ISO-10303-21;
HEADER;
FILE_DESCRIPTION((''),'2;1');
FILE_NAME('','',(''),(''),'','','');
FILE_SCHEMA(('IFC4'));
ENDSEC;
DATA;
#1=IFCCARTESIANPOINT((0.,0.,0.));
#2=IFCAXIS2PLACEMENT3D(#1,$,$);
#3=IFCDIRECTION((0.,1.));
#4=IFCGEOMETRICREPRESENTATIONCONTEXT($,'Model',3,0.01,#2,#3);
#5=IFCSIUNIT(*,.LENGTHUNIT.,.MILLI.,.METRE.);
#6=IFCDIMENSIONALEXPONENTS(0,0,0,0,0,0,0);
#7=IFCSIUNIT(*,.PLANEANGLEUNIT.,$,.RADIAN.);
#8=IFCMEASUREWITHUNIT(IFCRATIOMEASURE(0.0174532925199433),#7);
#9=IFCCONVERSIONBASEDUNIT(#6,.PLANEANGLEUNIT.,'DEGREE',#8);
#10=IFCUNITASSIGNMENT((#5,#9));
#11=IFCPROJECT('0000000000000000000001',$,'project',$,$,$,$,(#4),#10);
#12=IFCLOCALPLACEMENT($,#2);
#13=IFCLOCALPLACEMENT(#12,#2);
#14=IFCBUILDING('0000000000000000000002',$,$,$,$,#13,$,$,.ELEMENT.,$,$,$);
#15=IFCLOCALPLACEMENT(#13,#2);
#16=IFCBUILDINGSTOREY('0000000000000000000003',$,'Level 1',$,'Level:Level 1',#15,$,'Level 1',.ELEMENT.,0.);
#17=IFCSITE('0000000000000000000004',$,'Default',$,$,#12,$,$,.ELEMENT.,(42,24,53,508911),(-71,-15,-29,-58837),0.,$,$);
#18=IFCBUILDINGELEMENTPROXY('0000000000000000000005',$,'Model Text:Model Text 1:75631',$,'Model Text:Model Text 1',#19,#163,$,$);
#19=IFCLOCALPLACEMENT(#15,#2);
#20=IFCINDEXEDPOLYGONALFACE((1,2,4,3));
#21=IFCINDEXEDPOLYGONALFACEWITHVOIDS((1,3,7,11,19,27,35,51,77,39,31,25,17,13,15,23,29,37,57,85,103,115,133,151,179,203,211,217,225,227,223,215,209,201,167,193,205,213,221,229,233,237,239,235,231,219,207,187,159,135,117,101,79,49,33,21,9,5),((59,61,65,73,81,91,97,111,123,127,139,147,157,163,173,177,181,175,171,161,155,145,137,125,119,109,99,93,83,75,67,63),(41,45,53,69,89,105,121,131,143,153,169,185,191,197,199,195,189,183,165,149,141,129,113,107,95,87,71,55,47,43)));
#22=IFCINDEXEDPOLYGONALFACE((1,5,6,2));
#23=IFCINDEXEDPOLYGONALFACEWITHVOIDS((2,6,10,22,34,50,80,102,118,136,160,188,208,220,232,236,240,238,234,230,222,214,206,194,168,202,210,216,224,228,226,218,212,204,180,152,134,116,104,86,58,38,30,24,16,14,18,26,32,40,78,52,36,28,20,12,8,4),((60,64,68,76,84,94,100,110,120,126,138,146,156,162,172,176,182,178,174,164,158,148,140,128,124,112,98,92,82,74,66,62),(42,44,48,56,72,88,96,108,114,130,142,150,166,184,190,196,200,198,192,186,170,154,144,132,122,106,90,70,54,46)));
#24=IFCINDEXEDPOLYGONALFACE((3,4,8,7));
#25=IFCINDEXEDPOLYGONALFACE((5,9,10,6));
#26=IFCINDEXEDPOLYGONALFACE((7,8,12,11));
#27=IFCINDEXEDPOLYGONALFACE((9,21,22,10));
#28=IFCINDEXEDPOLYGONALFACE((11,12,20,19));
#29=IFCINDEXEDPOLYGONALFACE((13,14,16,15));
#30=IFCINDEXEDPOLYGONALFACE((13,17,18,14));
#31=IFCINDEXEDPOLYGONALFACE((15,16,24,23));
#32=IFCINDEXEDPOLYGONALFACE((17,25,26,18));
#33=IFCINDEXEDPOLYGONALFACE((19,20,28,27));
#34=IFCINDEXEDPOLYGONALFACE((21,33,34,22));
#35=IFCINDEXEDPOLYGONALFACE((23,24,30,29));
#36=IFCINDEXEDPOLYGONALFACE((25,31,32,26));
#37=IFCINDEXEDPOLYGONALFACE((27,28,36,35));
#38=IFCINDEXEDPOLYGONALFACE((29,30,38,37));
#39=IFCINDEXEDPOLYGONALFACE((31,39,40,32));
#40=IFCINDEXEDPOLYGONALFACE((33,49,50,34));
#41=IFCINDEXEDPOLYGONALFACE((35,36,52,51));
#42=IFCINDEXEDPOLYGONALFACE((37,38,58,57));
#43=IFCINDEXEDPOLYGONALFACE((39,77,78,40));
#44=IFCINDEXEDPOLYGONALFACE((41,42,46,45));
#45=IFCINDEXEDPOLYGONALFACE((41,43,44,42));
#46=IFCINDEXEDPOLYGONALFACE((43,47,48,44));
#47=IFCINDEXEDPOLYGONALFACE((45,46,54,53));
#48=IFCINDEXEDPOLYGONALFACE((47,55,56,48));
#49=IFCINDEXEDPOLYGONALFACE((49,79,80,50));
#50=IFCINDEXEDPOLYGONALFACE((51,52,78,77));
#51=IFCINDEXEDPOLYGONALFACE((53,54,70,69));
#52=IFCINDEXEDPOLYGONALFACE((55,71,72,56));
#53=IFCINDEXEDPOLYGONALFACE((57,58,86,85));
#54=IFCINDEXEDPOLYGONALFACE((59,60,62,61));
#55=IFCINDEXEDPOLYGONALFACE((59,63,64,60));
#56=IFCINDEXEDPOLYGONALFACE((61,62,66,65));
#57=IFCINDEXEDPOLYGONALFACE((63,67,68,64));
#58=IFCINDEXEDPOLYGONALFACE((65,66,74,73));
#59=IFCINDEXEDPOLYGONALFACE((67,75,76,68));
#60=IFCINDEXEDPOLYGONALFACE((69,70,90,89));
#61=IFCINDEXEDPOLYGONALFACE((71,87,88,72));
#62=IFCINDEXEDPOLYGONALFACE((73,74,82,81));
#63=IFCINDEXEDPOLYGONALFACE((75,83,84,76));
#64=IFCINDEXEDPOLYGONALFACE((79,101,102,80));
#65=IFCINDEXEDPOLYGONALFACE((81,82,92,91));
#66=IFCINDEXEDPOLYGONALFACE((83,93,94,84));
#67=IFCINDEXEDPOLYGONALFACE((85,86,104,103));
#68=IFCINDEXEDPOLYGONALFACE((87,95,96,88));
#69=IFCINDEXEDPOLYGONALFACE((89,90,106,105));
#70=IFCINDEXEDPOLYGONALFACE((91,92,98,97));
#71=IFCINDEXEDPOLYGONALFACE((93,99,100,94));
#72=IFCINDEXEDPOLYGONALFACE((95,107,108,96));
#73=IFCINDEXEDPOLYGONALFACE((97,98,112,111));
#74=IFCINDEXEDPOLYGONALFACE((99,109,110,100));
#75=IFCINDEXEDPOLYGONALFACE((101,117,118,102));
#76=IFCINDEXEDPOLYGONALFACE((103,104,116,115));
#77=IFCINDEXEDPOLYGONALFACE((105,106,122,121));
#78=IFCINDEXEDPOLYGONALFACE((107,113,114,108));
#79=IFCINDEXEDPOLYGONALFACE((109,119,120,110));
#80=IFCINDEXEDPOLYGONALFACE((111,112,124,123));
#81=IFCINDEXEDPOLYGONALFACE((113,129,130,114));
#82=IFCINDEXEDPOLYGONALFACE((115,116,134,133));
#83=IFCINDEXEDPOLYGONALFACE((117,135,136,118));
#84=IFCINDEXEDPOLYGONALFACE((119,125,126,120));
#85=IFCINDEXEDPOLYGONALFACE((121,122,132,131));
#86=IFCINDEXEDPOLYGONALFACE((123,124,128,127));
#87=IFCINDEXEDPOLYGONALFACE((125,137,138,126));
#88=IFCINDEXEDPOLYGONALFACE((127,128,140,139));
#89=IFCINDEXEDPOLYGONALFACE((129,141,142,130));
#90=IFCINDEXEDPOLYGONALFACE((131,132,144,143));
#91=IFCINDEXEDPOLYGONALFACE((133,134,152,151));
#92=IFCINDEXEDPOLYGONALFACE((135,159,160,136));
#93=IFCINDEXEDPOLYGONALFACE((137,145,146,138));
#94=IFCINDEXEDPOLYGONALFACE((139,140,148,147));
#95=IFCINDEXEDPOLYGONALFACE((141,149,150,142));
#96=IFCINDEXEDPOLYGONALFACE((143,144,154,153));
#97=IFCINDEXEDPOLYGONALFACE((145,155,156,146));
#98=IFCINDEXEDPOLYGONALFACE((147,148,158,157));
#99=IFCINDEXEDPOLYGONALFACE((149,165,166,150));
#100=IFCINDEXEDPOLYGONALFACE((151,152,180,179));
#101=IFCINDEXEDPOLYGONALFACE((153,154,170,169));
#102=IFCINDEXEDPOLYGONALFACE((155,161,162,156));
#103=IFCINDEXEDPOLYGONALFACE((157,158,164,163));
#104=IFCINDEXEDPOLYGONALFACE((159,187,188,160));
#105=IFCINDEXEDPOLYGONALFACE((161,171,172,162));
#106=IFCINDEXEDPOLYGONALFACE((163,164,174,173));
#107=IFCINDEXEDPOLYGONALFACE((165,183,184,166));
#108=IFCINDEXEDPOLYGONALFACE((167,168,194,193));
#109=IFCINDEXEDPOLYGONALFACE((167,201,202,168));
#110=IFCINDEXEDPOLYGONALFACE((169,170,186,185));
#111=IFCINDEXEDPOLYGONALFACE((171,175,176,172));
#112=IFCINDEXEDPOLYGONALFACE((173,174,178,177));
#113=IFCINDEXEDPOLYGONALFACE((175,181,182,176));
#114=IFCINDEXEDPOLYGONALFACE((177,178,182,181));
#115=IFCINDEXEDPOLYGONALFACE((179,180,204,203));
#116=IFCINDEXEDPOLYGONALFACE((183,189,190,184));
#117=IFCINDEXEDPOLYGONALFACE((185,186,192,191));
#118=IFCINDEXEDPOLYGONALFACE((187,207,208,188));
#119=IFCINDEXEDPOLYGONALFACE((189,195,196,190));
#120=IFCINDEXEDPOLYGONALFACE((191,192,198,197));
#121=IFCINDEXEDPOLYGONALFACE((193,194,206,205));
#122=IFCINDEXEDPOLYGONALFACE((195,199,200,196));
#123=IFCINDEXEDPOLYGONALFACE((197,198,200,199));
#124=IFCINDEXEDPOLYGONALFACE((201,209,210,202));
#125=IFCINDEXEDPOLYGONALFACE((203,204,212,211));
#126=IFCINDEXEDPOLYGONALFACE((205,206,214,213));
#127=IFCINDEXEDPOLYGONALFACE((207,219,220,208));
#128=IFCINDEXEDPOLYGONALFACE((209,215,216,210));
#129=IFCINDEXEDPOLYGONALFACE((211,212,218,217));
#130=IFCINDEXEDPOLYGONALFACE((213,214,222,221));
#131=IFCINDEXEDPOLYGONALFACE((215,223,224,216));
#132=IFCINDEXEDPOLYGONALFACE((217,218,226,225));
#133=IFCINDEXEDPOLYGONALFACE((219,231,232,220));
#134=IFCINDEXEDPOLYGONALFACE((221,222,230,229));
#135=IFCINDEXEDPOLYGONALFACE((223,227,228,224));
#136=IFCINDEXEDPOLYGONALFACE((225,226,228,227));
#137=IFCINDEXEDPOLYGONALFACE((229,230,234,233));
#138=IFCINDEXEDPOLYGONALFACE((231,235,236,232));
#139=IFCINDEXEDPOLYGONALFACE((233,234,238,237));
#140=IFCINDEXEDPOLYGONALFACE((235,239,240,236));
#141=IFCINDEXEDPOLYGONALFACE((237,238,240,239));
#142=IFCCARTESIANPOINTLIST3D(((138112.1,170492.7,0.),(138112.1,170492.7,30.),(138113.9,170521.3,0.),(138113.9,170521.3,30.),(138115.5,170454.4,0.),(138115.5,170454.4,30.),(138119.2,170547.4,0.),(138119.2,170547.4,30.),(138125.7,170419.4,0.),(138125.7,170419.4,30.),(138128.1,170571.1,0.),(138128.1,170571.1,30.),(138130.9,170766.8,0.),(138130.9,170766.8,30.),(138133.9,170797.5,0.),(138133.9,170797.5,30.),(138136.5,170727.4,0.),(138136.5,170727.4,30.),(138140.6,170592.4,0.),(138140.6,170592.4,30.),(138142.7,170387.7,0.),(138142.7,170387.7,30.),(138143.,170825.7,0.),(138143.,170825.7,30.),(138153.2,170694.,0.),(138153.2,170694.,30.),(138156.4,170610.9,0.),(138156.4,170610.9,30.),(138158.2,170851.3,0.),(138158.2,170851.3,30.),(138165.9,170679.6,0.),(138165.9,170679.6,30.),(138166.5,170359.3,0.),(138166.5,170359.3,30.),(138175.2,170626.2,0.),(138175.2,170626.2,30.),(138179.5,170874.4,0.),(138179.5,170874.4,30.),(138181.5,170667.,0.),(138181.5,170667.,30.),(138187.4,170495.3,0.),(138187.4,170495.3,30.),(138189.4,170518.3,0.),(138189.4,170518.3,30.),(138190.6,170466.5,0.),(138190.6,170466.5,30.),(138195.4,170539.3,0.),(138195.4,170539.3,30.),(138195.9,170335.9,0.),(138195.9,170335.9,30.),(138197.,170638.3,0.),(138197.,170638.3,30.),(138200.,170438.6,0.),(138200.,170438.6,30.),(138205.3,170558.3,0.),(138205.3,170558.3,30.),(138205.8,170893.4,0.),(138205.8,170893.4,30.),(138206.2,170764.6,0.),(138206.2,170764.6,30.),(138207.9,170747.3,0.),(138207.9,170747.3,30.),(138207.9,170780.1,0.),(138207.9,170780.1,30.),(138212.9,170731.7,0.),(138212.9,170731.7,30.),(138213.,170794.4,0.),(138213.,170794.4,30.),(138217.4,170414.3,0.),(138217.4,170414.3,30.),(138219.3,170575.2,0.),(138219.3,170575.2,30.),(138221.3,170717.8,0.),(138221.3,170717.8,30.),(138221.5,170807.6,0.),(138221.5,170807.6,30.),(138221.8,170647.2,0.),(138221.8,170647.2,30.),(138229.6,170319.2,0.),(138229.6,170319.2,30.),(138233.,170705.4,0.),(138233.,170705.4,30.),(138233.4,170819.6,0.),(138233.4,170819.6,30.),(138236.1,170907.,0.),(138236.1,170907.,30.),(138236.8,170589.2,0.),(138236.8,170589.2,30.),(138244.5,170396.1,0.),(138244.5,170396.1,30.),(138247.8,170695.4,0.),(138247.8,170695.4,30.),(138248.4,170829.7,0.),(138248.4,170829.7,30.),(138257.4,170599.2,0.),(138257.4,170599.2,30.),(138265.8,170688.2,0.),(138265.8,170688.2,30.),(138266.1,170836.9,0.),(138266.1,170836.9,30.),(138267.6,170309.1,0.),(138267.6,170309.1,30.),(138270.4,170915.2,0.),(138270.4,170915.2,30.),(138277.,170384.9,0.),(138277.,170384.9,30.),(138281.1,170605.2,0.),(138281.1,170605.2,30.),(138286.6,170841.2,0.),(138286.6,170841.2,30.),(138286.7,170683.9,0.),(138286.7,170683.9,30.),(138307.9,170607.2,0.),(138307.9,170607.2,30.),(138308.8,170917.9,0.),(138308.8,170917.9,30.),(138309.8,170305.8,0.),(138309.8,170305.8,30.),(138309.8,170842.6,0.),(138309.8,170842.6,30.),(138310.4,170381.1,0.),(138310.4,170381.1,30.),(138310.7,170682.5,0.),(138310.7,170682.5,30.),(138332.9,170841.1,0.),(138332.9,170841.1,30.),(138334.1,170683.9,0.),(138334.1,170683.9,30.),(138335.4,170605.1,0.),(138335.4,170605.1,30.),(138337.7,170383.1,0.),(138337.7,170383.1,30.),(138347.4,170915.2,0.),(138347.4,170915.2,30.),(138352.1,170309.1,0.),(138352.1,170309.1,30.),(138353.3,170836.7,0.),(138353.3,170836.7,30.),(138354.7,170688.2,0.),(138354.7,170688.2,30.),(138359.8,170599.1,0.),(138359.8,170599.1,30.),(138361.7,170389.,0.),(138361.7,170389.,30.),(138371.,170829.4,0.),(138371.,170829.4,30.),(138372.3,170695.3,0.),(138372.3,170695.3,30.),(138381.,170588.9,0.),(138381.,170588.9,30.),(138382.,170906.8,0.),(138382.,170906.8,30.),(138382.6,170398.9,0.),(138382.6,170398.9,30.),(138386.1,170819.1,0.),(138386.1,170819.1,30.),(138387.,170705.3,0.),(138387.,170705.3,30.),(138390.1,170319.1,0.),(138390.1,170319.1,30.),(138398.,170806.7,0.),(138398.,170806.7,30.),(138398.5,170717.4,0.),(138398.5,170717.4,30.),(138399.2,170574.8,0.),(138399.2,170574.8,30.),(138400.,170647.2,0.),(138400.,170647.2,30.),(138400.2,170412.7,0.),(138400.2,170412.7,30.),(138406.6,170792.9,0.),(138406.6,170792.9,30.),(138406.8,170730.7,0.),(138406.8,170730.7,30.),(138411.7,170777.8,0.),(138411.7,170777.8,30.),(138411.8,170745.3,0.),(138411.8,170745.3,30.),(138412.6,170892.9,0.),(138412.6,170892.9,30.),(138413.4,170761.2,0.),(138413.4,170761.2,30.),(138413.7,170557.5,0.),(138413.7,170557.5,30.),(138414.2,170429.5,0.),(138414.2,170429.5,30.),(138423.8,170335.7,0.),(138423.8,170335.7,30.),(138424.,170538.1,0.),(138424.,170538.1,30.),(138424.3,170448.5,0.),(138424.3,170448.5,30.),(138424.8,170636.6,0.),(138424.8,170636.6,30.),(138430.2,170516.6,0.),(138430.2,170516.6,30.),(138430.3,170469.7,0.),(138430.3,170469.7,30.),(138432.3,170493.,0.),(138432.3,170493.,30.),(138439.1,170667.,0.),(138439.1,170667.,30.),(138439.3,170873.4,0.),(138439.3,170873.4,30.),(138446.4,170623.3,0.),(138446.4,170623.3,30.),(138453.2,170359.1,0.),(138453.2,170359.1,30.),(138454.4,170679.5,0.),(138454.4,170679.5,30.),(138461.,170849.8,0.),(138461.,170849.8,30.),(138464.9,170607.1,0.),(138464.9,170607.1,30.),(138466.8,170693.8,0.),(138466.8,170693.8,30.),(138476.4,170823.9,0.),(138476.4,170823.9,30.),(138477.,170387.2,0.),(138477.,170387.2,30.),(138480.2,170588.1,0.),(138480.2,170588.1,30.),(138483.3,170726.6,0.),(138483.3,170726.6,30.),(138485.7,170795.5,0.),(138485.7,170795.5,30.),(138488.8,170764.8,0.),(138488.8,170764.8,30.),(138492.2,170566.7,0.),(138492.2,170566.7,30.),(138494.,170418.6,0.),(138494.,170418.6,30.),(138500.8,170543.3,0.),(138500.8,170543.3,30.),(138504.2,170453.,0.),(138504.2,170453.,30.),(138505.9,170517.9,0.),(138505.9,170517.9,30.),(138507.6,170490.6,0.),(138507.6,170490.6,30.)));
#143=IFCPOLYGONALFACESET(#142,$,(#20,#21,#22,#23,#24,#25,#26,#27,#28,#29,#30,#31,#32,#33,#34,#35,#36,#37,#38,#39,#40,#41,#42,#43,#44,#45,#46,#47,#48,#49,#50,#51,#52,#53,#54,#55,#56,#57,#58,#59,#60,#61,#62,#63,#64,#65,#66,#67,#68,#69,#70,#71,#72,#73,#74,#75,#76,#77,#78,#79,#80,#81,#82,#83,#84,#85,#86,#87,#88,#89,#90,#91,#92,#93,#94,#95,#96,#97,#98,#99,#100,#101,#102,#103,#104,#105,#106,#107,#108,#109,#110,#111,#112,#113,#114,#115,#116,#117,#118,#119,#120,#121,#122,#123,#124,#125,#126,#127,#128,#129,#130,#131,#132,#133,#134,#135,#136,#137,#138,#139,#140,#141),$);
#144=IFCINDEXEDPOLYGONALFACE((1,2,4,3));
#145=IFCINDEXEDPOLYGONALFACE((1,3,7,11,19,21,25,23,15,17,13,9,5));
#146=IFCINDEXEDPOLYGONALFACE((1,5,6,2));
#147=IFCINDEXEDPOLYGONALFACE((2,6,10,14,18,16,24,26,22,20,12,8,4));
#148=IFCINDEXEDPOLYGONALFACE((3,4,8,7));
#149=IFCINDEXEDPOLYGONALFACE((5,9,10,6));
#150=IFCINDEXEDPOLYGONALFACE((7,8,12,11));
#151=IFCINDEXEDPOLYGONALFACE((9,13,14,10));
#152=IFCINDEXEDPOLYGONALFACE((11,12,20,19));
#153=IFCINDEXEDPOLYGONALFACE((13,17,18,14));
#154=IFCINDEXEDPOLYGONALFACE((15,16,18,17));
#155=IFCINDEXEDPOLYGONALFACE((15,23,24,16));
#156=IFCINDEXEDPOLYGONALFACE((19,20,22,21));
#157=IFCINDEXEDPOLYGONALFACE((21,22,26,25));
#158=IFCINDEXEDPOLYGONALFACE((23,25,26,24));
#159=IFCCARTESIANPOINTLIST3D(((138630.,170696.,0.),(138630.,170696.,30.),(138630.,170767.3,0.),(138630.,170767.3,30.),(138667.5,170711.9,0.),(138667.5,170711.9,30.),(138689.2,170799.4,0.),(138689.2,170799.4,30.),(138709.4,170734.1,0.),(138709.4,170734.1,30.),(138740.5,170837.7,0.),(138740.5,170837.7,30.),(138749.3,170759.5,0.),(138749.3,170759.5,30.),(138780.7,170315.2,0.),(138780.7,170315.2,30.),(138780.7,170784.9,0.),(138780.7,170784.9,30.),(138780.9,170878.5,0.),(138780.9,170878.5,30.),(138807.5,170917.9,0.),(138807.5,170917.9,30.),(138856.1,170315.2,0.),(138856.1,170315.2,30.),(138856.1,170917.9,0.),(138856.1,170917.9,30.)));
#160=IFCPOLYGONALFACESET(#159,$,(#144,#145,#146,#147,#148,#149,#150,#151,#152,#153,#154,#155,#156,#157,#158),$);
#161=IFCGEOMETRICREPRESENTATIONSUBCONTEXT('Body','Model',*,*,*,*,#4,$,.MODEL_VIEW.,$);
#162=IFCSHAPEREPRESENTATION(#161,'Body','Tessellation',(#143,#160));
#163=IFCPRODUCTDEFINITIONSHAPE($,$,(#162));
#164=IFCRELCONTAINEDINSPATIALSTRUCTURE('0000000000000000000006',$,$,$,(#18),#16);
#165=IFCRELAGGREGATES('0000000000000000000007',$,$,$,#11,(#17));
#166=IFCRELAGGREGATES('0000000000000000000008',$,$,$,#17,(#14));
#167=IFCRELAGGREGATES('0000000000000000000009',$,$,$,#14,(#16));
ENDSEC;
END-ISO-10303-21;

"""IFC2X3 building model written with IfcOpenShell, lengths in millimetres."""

from ifc_helpers import new_model, entity, si_unit, converted_unit, direction, frame, origin, place, context, subcontext, project, spatial, polyline, outline, extrude, element, save


model = new_model("IFC2X3")

# Units and contexts
model_context = context("Model", 3, precision=0.01, world=origin(), true_north=direction((0.0, 1.0)))
body_context = subcontext(model_context, "Body", "Model", "MODEL_VIEW")
ifc_project = project(units=[si_unit("LENGTHUNIT", "METRE", prefix="MILLI"), converted_unit("PLANEANGLEUNIT", "DEGREE", entity("IfcRatioMeasure", 0.0174532925199433), si_unit("PLANEANGLEUNIT", "RADIAN"), dimensions=[0, 0, 0, 0, 0, 0, 0])], contexts=[model_context])

# Site, building, storey
site_placement = place(None, origin())
site = spatial("IfcSite", under=ifc_project, at=site_placement, Name="Default", CompositionType="ELEMENT", RefLatitude=(42, 24, 53, 508911), RefLongitude=(-71, -15, -29, -58837), RefElevation=0.0)
building_placement = place(site_placement, origin())
building = spatial("IfcBuilding", under=site, at=building_placement, CompositionType="ELEMENT")
storey_placement = place(building_placement, origin())
storey = spatial("IfcBuildingStorey", under=building, at=storey_placement, Name="Level 1", ObjectType="Level:Level 1", LongName="Level 1", CompositionType="ELEMENT", Elevation=0.0)

# Building element proxy
proxy_1_placement = place(storey_placement, origin())
element("IfcBuildingElementProxy", 1, at=proxy_1_placement, inside=storey, Name="Model Text:Model Text 1:75631", ObjectType="Model Text:Model Text 1", context=body_context, shape_type="SweptSolid", body=[
    extrude(outline(polyline([(74.3, -53.8), (100.6, -53.8), (125.3, -49.8), (148.1, -41.8), (169.2, -29.7), (188.1, -13.8), (204.5, 5.5), (218.4, 28.3), (229.7, 54.7), (239.4, 91.9), (241.6, 128.3), (236.2, 163.8), (223.4, 198.6), (203.6, 230.5), (177.5, 257.6), (145.1, 279.9), (106.4, 297.2), (65.5, 308.4), (26.4, 311.7), (-11.0, 307.4), (-46.5, 295.4), (-78.4, 276.8), (-105.0, 253.1), (-126.2, 224.1), (-142.0, 189.8), (-149.6, 163.5), (-153.3, 137.9), (-153.1, 113.0), (-149.0, 88.8), (-141.0, 65.8), (-129.1, 44.3), (-113.3, 24.5), (-93.5, 6.2), (-137.0, 0.7), (-155.5, -5.9), (-172.0, -15.2), (-198.6, -40.6), (-216.7, -74.6), (-224.1, -104.7), (-225.0, -134.5), (-219.1, -164.1), (-206.7, -193.5), (-188.1, -220.9), (-164.0, -244.3), (-134.2, -263.9), (-98.8, -279.5), (-61.8, -289.8), (-26.7, -293.7), (6.5, -291.1), (37.6, -282.0), (65.4, -267.5), (88.3, -248.5), (106.4, -225.0), (119.6, -197.1), (127.6, -158.1), (123.1, -121.0), (116.1, -103.3), (105.6, -86.1), (74.3, -53.8)]), holes=[polyline([(49.4, -169.7), (42.6, -183.7), (33.0, -195.4), (20.5, -205.0), (5.3, -212.3), (-12.2, -216.7), (-31.3, -217.5), (-52.0, -214.7), (-74.4, -208.2), (-95.6, -199.0), (-113.4, -188.0), (-127.6, -175.1), (-138.3, -160.4), (-145.4, -144.7), (-148.8, -128.8), (-148.5, -112.8), (-144.5, -96.7), (-137.6, -82.3), (-128.0, -70.2), (-115.7, -60.4), (-100.8, -52.9), (-83.6, -48.5), (-64.6, -47.7), (-43.8, -50.6), (-21.3, -57.2), (0.8, -66.6), (19.1, -77.7), (33.6, -90.5), (44.2, -105.0), (51.0, -120.5), (54.2, -136.4), (53.7, -152.8), (49.4, -169.7)]), polyline([(157.9, 77.5), (148.2, 56.6), (135.5, 38.8), (119.8, 24.3), (100.9, 13.0), (79.8, 5.8), (57.0, 3.3), (32.7, 5.7), (6.7, 12.8), (-18.5, 24.0), (-39.4, 37.9), (-56.0, 54.6), (-68.3, 74.1), (-76.1, 95.2), (-79.3, 116.9), (-77.9, 139.3), (-71.9, 162.2), (-62.2, 183.5), (-49.4, 201.4), (-33.6, 215.9), (-14.7, 227.0), (6.6, 234.1), (29.5, 236.4), (54.2, 233.8), (80.5, 226.5), (110.7, 211.7), (137.5, 190.2), (156.9, 164.0), (165.1, 135.2), (164.6, 105.7), (157.9, 77.5)])]), frame((138309.9, 170621.5, 0.0), z_axis=(0.0, 0.0, 1.0), x_axis=(-0.941552, -0.336867, 0.0)), (0.0, 0.0, 1.0), 30.0),
    extrude(outline(polyline([(-410.6, -111.6), (192.1, -111.6), (192.1, -63.1), (152.7, -36.4), (111.9, 4.0), (73.6, 55.2), (41.4, 114.4), (-29.8, 114.4), (-13.9, 77.0), (8.3, 35.1), (33.7, -4.8), (59.1, -36.3), (-410.6, -36.3), (-410.6, -111.6)])), frame((138744.5, 170725.8, 0.0), z_axis=(0.0, 0.0, 1.0), x_axis=(0.0, 1.0, 0.0)), (0.0, 0.0, 1.0), 30.0),
])

save(model, "model.ifc")
